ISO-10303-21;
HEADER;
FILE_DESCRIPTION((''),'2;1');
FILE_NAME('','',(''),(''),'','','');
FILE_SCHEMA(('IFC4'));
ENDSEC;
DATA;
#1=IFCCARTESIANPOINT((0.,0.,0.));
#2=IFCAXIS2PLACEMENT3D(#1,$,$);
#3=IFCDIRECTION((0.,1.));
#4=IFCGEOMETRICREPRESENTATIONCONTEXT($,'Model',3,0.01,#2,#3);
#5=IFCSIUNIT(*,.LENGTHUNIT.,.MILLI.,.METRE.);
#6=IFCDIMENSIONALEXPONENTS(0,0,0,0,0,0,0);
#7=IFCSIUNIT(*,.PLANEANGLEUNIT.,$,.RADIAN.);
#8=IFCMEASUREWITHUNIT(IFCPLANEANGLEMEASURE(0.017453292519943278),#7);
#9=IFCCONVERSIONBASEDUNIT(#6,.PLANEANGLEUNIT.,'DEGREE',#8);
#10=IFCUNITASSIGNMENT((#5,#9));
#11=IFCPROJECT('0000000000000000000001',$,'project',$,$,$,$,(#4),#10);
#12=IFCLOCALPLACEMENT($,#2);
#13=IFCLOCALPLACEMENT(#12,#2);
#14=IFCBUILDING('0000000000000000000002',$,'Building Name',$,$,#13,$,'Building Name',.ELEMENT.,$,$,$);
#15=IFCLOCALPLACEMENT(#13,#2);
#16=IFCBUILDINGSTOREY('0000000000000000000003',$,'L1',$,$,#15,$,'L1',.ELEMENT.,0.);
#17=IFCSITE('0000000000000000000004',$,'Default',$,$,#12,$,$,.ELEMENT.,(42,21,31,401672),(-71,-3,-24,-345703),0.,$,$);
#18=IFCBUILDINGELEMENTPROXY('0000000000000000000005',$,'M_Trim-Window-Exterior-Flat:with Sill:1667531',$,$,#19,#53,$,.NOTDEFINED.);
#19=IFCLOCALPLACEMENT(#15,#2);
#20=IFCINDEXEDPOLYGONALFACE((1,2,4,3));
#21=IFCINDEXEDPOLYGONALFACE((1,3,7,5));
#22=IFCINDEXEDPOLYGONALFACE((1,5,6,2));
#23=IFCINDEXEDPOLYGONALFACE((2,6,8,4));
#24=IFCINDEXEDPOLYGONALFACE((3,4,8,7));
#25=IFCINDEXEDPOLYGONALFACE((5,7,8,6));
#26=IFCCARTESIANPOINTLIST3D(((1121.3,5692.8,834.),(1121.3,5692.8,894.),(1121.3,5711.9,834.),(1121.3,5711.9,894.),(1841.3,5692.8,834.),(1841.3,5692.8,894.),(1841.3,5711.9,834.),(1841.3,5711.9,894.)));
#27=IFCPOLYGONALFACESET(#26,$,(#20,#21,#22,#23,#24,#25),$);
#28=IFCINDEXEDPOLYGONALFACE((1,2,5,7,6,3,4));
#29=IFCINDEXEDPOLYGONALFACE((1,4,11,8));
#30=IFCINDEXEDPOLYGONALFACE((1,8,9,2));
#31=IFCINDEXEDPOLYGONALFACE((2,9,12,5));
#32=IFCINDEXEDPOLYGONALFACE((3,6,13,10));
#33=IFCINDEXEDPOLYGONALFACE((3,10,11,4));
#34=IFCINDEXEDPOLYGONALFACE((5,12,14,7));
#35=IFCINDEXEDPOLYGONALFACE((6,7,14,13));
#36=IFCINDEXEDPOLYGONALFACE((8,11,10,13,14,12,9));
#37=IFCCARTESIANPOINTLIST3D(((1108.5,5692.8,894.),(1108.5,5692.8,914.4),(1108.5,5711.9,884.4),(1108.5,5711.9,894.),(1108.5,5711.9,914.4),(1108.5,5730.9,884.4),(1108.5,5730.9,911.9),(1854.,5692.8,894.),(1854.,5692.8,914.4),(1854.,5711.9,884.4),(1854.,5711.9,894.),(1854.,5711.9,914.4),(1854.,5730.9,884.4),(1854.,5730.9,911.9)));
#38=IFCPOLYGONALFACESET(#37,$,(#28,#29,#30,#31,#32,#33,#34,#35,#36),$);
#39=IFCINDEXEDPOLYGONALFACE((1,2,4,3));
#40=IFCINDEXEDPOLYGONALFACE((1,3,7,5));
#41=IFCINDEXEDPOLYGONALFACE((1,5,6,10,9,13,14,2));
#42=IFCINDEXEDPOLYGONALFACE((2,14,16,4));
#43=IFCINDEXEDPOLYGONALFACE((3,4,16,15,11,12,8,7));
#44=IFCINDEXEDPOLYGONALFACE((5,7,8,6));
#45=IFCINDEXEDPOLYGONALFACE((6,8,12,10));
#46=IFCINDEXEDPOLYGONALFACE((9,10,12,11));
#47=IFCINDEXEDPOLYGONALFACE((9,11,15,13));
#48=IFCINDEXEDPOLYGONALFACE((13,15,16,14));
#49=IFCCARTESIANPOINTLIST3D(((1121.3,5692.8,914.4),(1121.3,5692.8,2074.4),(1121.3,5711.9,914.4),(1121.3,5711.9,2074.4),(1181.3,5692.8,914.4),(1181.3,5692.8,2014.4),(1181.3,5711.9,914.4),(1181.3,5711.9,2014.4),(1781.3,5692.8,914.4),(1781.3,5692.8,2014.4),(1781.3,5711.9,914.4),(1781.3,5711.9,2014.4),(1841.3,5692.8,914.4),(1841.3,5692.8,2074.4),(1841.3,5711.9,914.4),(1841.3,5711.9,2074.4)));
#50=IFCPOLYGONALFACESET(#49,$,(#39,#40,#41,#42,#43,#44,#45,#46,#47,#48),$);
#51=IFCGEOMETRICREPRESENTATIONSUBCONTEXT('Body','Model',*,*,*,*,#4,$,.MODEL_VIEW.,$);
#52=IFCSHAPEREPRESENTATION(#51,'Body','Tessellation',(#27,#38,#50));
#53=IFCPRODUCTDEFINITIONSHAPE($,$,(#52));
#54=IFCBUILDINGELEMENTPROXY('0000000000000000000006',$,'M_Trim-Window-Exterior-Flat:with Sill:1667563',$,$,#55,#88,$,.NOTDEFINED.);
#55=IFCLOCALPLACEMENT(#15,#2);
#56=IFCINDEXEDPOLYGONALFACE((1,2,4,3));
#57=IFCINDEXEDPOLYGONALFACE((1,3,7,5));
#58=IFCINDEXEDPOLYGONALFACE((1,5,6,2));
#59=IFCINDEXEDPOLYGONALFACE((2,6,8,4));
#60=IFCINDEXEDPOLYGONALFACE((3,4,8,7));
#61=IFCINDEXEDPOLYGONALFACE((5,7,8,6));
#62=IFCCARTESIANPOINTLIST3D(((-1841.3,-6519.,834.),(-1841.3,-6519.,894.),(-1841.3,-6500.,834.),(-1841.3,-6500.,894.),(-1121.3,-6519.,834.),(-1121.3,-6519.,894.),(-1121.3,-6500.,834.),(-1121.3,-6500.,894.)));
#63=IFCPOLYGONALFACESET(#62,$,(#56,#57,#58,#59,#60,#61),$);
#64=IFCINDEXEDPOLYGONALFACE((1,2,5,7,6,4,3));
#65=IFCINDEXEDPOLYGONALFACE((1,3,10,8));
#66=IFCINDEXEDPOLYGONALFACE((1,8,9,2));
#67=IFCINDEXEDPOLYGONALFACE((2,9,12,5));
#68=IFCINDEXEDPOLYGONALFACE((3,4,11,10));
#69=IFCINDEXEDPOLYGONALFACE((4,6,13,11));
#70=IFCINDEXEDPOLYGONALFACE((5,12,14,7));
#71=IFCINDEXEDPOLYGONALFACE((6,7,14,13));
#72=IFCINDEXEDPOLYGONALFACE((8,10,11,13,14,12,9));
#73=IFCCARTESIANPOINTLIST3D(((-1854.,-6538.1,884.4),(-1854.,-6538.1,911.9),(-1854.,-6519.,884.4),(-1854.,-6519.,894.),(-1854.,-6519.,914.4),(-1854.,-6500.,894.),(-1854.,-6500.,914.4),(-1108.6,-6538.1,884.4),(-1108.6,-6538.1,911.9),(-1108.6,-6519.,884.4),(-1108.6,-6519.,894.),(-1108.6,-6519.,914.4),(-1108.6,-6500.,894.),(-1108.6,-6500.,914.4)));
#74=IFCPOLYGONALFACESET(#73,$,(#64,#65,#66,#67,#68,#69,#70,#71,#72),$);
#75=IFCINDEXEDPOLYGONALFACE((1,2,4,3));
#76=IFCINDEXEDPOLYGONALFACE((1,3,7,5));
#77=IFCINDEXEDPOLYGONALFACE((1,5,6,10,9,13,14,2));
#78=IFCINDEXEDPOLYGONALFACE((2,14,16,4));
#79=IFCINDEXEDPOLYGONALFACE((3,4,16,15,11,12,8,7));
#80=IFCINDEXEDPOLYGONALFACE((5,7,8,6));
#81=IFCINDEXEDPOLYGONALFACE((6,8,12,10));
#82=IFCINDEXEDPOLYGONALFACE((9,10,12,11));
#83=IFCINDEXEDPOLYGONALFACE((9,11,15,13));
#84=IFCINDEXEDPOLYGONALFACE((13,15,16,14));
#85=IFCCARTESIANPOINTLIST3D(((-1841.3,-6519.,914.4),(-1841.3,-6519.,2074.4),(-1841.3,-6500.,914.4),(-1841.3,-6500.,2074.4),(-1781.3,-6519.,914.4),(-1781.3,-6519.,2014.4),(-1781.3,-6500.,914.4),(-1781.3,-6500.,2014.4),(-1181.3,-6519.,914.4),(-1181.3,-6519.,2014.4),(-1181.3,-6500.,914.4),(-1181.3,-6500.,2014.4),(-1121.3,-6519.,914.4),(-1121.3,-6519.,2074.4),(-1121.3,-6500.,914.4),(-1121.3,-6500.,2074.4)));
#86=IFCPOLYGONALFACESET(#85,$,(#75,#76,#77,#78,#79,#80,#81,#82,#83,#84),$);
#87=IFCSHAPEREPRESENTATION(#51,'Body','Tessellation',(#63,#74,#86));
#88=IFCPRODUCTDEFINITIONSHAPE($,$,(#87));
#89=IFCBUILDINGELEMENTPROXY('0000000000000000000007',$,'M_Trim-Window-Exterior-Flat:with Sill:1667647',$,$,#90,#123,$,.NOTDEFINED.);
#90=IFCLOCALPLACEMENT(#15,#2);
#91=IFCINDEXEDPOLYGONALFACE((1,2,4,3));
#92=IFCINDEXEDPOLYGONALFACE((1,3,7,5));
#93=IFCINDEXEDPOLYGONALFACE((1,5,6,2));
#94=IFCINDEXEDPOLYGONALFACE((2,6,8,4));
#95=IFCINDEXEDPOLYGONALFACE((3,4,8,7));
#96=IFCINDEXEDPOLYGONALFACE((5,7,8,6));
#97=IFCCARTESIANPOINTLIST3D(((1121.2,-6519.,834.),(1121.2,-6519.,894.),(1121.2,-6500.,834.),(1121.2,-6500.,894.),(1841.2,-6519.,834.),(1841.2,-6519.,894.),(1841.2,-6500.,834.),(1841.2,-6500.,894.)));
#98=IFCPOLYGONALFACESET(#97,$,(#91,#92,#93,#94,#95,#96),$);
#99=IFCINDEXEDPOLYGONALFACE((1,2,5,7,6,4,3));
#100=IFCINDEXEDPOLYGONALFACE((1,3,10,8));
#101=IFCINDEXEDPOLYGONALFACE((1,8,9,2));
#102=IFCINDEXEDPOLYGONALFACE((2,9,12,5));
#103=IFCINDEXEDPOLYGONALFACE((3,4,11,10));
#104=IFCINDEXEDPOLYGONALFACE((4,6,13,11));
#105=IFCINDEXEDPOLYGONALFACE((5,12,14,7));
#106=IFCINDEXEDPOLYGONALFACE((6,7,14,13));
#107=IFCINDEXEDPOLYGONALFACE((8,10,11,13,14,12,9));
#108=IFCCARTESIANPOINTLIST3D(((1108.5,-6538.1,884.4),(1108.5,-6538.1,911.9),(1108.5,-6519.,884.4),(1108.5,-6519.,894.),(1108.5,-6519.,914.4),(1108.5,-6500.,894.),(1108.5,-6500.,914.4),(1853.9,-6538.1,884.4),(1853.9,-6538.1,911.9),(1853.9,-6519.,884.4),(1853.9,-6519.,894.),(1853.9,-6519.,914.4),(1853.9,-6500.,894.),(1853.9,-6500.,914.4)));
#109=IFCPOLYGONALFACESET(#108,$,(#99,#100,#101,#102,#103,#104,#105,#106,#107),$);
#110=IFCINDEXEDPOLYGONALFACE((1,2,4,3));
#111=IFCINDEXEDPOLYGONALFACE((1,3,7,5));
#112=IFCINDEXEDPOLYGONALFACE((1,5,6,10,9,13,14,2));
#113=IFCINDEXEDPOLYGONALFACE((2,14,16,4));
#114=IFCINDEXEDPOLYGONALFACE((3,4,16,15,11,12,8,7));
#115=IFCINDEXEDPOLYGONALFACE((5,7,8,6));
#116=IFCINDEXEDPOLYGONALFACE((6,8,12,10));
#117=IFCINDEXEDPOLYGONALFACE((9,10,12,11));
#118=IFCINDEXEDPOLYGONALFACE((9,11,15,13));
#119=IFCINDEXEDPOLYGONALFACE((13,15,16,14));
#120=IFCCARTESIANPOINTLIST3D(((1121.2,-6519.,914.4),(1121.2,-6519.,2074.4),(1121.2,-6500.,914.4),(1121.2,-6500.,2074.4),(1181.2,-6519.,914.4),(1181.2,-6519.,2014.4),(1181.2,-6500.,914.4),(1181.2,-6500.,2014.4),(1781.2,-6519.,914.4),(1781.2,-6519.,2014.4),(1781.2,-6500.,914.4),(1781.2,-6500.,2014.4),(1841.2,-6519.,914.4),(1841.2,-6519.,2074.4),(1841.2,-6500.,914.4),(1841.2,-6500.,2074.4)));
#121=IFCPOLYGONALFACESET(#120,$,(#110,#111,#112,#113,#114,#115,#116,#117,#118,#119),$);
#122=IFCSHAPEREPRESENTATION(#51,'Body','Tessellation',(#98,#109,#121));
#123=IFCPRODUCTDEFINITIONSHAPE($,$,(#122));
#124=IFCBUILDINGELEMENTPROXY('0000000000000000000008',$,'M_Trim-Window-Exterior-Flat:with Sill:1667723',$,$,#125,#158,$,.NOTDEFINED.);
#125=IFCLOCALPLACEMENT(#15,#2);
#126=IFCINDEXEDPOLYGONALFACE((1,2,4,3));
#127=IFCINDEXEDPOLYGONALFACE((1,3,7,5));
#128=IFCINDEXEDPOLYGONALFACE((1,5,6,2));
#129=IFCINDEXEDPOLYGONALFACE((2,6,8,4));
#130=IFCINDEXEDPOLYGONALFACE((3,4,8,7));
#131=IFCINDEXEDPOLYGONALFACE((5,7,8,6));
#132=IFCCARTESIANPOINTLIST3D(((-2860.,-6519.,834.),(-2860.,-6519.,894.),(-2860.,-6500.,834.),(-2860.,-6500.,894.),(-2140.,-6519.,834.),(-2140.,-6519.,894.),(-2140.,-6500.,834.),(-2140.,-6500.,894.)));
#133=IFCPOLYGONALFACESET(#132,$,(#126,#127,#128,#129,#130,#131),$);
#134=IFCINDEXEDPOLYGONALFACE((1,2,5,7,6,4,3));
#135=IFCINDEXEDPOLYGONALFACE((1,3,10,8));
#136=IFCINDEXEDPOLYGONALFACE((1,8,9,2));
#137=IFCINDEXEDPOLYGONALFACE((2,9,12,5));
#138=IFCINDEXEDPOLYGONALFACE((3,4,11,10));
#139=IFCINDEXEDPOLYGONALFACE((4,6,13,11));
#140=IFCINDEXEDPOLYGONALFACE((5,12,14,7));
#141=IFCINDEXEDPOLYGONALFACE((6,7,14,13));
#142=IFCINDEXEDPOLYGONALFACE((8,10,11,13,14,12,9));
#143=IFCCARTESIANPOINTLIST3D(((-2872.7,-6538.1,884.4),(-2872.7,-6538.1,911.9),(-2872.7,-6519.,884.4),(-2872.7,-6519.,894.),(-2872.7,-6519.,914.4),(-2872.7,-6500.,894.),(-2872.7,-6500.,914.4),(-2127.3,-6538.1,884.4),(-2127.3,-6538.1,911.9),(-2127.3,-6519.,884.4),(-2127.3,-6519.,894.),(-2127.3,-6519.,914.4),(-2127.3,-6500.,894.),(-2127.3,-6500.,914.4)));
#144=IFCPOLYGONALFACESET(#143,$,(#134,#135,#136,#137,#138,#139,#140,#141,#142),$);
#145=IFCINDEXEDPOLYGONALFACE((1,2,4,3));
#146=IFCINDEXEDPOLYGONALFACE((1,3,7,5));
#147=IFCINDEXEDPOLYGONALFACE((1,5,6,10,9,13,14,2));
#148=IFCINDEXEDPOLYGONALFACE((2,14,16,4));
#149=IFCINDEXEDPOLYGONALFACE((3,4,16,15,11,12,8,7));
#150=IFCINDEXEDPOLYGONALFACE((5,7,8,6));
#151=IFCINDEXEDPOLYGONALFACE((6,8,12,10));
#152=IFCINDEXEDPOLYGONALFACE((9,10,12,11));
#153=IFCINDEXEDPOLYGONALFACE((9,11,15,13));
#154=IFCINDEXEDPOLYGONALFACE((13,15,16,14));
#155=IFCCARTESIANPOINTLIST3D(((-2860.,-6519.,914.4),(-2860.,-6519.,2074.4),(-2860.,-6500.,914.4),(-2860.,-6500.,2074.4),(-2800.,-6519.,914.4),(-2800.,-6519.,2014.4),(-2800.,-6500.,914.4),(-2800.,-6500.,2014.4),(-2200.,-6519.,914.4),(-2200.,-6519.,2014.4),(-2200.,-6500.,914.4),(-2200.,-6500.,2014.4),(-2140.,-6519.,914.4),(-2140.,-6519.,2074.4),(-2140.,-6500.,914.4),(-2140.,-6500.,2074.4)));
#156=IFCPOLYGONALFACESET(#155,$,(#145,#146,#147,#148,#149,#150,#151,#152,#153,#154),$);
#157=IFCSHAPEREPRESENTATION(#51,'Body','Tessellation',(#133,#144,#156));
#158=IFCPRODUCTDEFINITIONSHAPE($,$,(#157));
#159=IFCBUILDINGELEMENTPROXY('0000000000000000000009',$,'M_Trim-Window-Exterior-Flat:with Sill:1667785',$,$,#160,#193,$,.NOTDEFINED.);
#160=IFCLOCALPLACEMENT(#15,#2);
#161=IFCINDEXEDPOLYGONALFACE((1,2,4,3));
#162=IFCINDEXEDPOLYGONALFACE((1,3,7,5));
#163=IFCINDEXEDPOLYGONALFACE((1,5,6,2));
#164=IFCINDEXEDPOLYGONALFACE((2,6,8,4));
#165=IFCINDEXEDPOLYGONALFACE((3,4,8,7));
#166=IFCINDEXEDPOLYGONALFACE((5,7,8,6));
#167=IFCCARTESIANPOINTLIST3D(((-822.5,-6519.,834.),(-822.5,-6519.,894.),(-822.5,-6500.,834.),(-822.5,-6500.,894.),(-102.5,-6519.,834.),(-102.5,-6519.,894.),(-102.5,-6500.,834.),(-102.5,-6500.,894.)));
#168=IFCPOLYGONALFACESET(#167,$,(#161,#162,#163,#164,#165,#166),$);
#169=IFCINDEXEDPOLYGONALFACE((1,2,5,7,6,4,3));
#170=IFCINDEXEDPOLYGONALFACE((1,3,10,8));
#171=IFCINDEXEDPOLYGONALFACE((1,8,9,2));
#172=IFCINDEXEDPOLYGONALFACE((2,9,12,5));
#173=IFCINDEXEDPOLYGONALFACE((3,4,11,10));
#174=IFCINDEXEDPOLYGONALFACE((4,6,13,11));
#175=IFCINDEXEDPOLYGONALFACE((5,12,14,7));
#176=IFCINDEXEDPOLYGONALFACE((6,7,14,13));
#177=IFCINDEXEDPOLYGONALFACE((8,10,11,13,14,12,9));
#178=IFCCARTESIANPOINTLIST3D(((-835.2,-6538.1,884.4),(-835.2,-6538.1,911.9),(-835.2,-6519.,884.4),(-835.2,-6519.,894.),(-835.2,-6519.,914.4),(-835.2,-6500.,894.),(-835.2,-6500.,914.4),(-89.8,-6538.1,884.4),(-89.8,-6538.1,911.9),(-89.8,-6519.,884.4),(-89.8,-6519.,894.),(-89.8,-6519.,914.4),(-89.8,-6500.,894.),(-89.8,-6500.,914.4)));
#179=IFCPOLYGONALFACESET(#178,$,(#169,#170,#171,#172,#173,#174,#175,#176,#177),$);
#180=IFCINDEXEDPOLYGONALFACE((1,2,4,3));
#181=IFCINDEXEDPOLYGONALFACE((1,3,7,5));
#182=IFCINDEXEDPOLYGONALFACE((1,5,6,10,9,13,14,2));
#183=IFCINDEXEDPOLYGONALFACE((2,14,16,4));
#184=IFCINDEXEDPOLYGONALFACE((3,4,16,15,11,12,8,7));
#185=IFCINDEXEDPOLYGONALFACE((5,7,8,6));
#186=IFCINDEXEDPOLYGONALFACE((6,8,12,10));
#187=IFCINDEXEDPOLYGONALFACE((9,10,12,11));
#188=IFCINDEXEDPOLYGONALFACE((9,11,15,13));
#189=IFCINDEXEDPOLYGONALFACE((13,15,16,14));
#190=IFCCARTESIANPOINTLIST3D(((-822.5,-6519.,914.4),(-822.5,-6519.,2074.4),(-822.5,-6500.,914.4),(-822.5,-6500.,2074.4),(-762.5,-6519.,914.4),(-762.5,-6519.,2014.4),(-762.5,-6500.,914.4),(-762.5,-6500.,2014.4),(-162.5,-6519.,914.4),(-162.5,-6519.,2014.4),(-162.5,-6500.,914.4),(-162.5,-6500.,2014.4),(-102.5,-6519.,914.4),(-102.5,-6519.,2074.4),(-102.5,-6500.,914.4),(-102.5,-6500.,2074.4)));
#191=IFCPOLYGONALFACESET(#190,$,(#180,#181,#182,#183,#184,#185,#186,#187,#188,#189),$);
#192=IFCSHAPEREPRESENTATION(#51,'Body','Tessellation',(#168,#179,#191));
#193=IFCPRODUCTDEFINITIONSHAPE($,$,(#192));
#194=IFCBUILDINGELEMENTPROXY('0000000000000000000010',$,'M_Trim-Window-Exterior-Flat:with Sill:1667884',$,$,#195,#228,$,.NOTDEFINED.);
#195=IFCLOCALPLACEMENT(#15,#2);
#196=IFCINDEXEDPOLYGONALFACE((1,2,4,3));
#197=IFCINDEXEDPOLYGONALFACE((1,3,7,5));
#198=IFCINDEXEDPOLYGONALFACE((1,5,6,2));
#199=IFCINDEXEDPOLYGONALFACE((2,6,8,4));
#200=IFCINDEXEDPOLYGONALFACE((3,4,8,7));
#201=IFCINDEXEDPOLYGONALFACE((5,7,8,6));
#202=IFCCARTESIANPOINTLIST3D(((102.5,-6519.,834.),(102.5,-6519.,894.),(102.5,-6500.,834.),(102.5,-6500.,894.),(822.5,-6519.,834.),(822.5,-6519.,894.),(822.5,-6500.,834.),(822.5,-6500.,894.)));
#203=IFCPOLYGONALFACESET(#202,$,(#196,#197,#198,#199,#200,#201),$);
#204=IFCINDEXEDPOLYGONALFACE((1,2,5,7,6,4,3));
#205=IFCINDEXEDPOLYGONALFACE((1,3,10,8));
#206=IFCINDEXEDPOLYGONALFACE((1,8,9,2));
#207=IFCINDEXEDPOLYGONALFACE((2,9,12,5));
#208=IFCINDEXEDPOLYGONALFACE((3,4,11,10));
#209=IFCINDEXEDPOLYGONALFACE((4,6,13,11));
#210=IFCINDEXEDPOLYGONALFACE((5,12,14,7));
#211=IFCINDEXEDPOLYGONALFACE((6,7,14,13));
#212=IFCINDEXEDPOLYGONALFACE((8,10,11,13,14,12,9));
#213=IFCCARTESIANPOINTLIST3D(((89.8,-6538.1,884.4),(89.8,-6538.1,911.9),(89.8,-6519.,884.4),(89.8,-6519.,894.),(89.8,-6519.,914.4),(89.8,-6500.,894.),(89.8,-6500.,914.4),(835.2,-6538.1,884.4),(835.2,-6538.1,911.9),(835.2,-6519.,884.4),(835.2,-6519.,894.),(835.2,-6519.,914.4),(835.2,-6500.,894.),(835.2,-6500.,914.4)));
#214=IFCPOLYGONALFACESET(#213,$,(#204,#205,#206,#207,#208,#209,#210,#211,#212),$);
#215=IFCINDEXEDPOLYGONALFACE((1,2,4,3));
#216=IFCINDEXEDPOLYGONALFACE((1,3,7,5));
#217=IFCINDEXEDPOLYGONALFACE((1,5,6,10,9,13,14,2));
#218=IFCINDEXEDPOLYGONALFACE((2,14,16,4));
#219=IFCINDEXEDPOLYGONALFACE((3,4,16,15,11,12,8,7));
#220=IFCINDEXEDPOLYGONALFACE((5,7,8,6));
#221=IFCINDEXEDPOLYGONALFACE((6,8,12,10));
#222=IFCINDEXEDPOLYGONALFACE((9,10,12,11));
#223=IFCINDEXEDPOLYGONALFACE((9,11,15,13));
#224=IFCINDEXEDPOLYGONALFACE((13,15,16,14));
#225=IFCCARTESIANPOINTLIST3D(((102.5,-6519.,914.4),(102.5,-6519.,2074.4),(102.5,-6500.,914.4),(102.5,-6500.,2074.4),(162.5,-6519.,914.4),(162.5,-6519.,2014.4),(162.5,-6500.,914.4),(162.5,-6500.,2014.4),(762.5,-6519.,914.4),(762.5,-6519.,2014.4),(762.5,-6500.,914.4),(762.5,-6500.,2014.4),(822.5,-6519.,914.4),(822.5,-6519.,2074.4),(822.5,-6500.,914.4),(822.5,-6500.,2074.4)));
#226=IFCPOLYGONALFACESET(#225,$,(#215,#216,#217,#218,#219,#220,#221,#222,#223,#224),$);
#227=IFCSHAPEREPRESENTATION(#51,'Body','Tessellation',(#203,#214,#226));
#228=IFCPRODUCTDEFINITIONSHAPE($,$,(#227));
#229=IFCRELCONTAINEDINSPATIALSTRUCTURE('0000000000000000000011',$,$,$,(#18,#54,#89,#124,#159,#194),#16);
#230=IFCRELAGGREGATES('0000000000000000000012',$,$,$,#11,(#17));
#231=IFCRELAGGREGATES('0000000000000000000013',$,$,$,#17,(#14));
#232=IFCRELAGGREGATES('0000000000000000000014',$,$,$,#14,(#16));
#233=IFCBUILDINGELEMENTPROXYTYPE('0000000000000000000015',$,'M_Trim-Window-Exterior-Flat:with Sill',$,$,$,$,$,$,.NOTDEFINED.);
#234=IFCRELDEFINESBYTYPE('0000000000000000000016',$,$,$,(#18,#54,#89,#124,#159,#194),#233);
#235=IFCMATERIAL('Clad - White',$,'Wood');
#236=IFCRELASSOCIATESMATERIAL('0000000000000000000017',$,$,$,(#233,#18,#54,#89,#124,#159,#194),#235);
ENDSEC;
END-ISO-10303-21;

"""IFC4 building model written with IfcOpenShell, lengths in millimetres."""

from ifc_helpers import new_model, entity, si_unit, converted_unit, direction, frame, origin, place, context, subcontext, project, spatial, indexed_curve, outline, extrude, source, transform, mapped, material, type_object, type_shapes, element, save


model = new_model("IFC4")

# Units and contexts
model_context = context("Model", 3, precision=0.01, world=origin(), true_north=direction((0.0, 1.0)))
body_context = subcontext(model_context, "Body", "Model", "MODEL_VIEW")
ifc_project = project(units=[si_unit("LENGTHUNIT", "METRE", prefix="MILLI"), converted_unit("PLANEANGLEUNIT", "DEGREE", entity("IfcPlaneAngleMeasure", 0.017453292519943278), si_unit("PLANEANGLEUNIT", "RADIAN"), dimensions=[0, 0, 0, 0, 0, 0, 0])], contexts=[model_context])

# Site, building, storey
site_placement = place(None, origin())
site = spatial("IfcSite", under=ifc_project, at=site_placement, Name="Default", CompositionType="ELEMENT", RefLatitude=(42, 21, 31, 401672), RefLongitude=(-71, -3, -24, -345703), RefElevation=0.0)
building_placement = place(site_placement, origin())
building = spatial("IfcBuilding", under=site, at=building_placement, Name="Building Name", LongName="Building Name", CompositionType="ELEMENT")
storey_placement = place(building_placement, origin())
storey = spatial("IfcBuildingStorey", under=building, at=storey_placement, Name="L1", LongName="L1", CompositionType="ELEMENT", Elevation=0.0)

# Building element proxies
ifc_material_1 = material(Name="Clad - White", Category="Wood")
building_element_proxy_type_1 = type_object("IfcBuildingElementProxyType", Name="M_Trim-Window-Exterior-Flat:with Sill", PredefinedType="NOTDEFINED", material=ifc_material_1)
shared_shape_1 = source(origin(), body_context, "Body", "SweptSolid", [
    extrude(outline(indexed_curve([(-360.0, -30.0), (360.0, -30.0), (360.0, 30.0), (-360.0, 30.0), (-360.0, -30.0)], self_intersect=False)), frame((0.0, -1150.4, 0.0), z_axis=(0.0, 0.0, 1.0), x_axis=(-1.0, 0.0, 0.0)), (0.0, 0.0, 1.0), 19.0),
    extrude(outline(indexed_curve([(-19.0, -15.2), (0.0, -15.2), (0.0, -5.7), (19.0, -5.7), (19.0, 14.8), (0.0, 14.8), (-19.0, 12.3), (-19.0, -15.2)], self_intersect=False)), frame((-372.7, -1114.8, 19.0), z_axis=(1.0, 0.0, 0.0), x_axis=(0.0, 0.0, -1.0)), (0.0, 0.0, 1.0), 745.4),
    extrude(outline(indexed_curve([(-595.0, -360.0), (565.0, -360.0), (565.0, -300.0), (-535.0, -300.0), (-535.0, 300.0), (565.0, 300.0), (565.0, 360.0), (-595.0, 360.0), (-595.0, -360.0)], self_intersect=False)), frame((0.0, -535.0, 0.0), z_axis=(0.0, 0.0, 1.0), x_axis=(0.0, -1.0, 0.0)), (0.0, 0.0, 1.0), 19.0),
])
type_shapes(building_element_proxy_type_1, [shared_shape_1])
for number, where, z_axis, x_axis, name in (
    (1, (1481.3, 5692.8, 2014.4), (0.0, 1.0, 0.0), (-1.0, 0.0, 0.0), "M_Trim-Window-Exterior-Flat:with Sill:1667531"),
    (2, (-1481.3, -6500.0, 2014.4), (0.0, -1.0, 0.0), (1.0, 0.0, 0.0), "M_Trim-Window-Exterior-Flat:with Sill:1667563"),
    (3, (1481.2, -6500.0, 2014.4), (0.0, -1.0, 0.0), (1.0, 0.0, 0.0), "M_Trim-Window-Exterior-Flat:with Sill:1667647"),
    (4, (-2500.0, -6500.0, 2014.4), (0.0, -1.0, 0.0), (1.0, 0.0, 0.0), "M_Trim-Window-Exterior-Flat:with Sill:1667723"),
    (5, (-462.5, -6500.0, 2014.4), (0.0, -1.0, 0.0), (1.0, 0.0, 0.0), "M_Trim-Window-Exterior-Flat:with Sill:1667785"),
    (6, (462.5, -6500.0, 2014.4), (0.0, -1.0, 0.0), (1.0, 0.0, 0.0), "M_Trim-Window-Exterior-Flat:with Sill:1667884"),
):
    element("IfcBuildingElementProxy", number, at=place(storey_placement, frame(where, z_axis=z_axis, x_axis=x_axis)), inside=storey, type_object=building_element_proxy_type_1, material=ifc_material_1, Name=name, PredefinedType="NOTDEFINED", context=body_context, shape_type="MappedRepresentation", body=[
        mapped(shared_shape_1, transform((0.0, 0.0, 0.0), scale=1.0)),
    ])

save(model, "model.ifc")
